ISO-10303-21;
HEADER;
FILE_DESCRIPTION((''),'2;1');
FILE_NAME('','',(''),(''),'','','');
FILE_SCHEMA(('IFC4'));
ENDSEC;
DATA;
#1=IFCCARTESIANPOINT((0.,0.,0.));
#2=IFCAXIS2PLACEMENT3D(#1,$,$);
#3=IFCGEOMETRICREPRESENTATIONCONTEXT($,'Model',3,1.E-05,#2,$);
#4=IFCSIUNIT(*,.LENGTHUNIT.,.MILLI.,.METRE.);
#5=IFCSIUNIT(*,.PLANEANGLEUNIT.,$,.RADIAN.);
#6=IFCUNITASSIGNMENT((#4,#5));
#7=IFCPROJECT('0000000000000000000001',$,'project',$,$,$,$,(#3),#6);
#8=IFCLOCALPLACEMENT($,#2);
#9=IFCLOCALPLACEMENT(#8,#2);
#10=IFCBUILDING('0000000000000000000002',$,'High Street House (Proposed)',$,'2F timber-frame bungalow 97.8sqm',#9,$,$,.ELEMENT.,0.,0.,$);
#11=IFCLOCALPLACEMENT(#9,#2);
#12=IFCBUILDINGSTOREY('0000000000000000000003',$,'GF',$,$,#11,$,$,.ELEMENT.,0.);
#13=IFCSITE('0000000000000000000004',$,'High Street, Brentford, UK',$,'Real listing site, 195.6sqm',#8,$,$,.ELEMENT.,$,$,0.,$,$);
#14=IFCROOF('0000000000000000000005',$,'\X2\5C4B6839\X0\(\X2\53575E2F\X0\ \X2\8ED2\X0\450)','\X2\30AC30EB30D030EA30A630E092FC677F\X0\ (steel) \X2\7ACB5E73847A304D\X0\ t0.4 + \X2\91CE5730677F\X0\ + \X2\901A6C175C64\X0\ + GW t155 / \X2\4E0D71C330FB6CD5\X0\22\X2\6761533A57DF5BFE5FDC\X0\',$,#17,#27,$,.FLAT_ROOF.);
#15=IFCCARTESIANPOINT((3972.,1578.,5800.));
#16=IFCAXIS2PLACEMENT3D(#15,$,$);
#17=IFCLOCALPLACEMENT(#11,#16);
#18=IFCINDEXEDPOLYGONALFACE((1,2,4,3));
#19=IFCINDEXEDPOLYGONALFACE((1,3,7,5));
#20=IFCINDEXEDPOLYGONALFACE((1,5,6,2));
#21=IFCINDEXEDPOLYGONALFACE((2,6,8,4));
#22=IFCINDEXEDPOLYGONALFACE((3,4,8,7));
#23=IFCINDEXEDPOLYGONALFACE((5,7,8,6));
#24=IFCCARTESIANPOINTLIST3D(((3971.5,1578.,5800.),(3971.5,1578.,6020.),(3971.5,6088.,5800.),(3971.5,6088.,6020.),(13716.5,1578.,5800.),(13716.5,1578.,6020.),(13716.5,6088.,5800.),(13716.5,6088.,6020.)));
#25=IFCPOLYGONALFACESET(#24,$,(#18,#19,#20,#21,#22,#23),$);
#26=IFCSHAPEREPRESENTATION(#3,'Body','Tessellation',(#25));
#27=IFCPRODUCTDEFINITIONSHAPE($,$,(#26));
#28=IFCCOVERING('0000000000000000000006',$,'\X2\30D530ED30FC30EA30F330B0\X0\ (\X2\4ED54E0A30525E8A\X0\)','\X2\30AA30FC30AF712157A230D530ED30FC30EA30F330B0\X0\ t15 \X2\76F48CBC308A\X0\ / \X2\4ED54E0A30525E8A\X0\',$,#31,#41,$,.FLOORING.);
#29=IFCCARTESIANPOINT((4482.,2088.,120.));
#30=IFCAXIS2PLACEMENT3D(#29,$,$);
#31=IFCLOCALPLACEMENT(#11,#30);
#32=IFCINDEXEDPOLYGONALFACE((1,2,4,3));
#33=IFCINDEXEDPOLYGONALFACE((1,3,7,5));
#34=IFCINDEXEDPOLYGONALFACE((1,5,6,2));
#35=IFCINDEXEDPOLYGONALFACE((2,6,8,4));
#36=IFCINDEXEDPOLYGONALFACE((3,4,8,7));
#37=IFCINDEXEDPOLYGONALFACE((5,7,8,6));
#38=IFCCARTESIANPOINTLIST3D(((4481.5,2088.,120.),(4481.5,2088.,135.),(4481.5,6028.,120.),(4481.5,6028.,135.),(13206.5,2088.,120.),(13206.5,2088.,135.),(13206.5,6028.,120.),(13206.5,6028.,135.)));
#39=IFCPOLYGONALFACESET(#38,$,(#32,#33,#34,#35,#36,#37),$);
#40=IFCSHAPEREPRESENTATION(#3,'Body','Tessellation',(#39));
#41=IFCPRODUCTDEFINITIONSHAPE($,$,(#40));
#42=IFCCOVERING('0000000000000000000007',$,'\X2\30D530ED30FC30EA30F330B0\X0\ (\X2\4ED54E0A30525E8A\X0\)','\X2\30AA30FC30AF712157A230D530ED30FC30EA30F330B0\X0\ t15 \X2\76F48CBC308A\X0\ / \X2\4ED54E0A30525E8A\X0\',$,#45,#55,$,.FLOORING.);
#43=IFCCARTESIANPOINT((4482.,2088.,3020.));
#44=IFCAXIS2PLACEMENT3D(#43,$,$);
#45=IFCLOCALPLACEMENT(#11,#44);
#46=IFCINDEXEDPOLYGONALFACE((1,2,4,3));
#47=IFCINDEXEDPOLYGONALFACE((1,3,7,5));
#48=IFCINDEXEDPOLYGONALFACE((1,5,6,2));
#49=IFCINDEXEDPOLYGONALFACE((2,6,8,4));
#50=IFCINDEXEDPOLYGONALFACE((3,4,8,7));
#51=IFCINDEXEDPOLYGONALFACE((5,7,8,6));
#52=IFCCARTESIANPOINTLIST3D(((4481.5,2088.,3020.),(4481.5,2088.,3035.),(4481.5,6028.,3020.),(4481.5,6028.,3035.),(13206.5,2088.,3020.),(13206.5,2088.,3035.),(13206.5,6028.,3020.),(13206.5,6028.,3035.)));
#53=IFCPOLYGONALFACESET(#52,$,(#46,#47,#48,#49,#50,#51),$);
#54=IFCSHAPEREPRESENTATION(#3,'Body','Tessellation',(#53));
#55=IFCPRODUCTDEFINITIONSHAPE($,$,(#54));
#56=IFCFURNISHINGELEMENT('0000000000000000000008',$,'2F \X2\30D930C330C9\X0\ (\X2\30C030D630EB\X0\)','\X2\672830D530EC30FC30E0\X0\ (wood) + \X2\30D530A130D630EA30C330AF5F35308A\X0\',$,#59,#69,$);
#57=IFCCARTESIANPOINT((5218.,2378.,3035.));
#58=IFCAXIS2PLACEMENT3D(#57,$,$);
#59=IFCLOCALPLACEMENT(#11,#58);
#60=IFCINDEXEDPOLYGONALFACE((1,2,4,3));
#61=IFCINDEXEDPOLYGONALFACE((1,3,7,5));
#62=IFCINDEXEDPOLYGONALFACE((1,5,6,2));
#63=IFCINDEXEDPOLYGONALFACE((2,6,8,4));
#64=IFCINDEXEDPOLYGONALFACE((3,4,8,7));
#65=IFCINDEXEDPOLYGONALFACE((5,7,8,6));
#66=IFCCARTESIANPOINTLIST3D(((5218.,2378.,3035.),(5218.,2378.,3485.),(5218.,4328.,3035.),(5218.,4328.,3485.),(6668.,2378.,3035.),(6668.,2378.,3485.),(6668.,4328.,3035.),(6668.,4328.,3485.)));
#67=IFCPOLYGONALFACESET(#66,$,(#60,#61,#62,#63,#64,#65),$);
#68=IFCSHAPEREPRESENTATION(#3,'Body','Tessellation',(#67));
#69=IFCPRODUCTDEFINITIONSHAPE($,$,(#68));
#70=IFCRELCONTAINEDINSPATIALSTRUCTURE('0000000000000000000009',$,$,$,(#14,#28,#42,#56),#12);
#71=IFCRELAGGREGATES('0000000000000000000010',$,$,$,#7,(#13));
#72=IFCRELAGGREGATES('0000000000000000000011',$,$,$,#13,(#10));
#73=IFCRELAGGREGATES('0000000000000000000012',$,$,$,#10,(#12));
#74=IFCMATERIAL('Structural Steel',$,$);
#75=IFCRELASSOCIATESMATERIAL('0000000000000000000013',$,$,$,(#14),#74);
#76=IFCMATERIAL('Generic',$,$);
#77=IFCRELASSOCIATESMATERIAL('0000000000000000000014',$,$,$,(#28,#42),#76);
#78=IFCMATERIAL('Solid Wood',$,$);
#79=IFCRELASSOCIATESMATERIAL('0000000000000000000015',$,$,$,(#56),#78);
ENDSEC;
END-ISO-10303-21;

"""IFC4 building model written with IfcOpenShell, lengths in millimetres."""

from ifc_helpers import new_model, si_unit, frame, frame_2d, origin, place, context, project, spatial, rectangle, extrude, material, element, save


model = new_model("IFC4")

# Units and contexts
model_context = context("Model", 3, precision=1e-05, world=origin())
ifc_project = project(units=[si_unit("LENGTHUNIT", "METRE", prefix="MILLI"), si_unit("PLANEANGLEUNIT", "RADIAN")], contexts=[model_context])

# Site, building, storey
site_placement = place(None, origin())
site = spatial("IfcSite", under=ifc_project, at=site_placement, Name="High Street, Brentford, UK", ObjectType="Real listing site, 195.6sqm", CompositionType="ELEMENT", RefElevation=0.0)
building_placement = place(site_placement, origin())
building = spatial("IfcBuilding", under=site, at=building_placement, Name="High Street House (Proposed)", ObjectType="2F timber-frame bungalow 97.8sqm", CompositionType="ELEMENT", ElevationOfRefHeight=0.0, ElevationOfTerrain=0.0)
storey_placement = place(building_placement, origin())
storey = spatial("IfcBuildingStorey", under=building, at=storey_placement, Name="GF", CompositionType="ELEMENT", Elevation=0.0)

# Shared definitions
ifc_material_1 = material(Name="Solid Wood")

# Roof
ifc_material_2 = material(Name="Structural Steel")
for number, where, name in (
    (1, (3972.0, 1578.0, 5800.0), "屋根(南帯 軒450)"),
):
    element("IfcRoof", number, at=place(storey_placement, frame(where)), inside=storey, material=ifc_material_2, Name=name, Description="ガルバリウム鋼板 (steel) 立平葺き t0.4 + 野地板 + 通気層 + GW t155 / 不燃・法22条区域対応", PredefinedType="FLAT_ROOF", context=model_context, shape_type="SweptSolid", body=[
        extrude(rectangle(XDim=9745.0, YDim=4510.0, at=frame_2d((4872.0, 2255.0))), frame((3972.0, 1578.0, 5800.0)), (0.0, 0.0, 1.0), 220.0),
    ])

# Coverings
ifc_material_3 = material(Name="Generic")
covering_1_placement = place(storey_placement, frame((4482.0, 2088.0, 120.0)))
element("IfcCovering", 2, at=covering_1_placement, inside=storey, material=ifc_material_3, Name="フローリング (仕上げ床)", Description="オーク無垢フローリング t15 直貼り / 仕上げ床", PredefinedType="FLOORING", context=model_context, shape_type="SweptSolid", body=[
    extrude(rectangle(XDim=8725.0, YDim=3940.0, at=frame_2d((4362.0, 1970.0))), frame((4482.0, 2088.0, 120.0)), (0.0, 0.0, 1.0), 15.0),
])
covering_2_placement = place(storey_placement, frame((4482.0, 2088.0, 3020.0)))
element("IfcCovering", 3, at=covering_2_placement, inside=storey, material=ifc_material_3, Name="フローリング (仕上げ床)", Description="オーク無垢フローリング t15 直貼り / 仕上げ床", PredefinedType="FLOORING", context=model_context, shape_type="SweptSolid", body=[
    extrude(rectangle(XDim=8725.0, YDim=3940.0, at=frame_2d((4362.0, 1970.0))), frame((4482.0, 2088.0, 3020.0)), (0.0, 0.0, 1.0), 15.0),
])

# Furnishing element
furnishing_placement = place(storey_placement, frame((5218.0, 2378.0, 3035.0)))
element("IfcFurnishingElement", 4, at=furnishing_placement, inside=storey, material=ifc_material_1, Name="2F ベッド (ダブル)", Description="木フレーム (wood) + ファブリック張り", context=model_context, shape_type="SweptSolid", body=[
    extrude(rectangle(XDim=1450.0, YDim=1950.0, at=frame_2d((725.0, 975.0))), frame((5218.0, 2378.0, 3035.0)), (0.0, 0.0, 1.0), 450.0),
])

save(model, "model.ifc")
